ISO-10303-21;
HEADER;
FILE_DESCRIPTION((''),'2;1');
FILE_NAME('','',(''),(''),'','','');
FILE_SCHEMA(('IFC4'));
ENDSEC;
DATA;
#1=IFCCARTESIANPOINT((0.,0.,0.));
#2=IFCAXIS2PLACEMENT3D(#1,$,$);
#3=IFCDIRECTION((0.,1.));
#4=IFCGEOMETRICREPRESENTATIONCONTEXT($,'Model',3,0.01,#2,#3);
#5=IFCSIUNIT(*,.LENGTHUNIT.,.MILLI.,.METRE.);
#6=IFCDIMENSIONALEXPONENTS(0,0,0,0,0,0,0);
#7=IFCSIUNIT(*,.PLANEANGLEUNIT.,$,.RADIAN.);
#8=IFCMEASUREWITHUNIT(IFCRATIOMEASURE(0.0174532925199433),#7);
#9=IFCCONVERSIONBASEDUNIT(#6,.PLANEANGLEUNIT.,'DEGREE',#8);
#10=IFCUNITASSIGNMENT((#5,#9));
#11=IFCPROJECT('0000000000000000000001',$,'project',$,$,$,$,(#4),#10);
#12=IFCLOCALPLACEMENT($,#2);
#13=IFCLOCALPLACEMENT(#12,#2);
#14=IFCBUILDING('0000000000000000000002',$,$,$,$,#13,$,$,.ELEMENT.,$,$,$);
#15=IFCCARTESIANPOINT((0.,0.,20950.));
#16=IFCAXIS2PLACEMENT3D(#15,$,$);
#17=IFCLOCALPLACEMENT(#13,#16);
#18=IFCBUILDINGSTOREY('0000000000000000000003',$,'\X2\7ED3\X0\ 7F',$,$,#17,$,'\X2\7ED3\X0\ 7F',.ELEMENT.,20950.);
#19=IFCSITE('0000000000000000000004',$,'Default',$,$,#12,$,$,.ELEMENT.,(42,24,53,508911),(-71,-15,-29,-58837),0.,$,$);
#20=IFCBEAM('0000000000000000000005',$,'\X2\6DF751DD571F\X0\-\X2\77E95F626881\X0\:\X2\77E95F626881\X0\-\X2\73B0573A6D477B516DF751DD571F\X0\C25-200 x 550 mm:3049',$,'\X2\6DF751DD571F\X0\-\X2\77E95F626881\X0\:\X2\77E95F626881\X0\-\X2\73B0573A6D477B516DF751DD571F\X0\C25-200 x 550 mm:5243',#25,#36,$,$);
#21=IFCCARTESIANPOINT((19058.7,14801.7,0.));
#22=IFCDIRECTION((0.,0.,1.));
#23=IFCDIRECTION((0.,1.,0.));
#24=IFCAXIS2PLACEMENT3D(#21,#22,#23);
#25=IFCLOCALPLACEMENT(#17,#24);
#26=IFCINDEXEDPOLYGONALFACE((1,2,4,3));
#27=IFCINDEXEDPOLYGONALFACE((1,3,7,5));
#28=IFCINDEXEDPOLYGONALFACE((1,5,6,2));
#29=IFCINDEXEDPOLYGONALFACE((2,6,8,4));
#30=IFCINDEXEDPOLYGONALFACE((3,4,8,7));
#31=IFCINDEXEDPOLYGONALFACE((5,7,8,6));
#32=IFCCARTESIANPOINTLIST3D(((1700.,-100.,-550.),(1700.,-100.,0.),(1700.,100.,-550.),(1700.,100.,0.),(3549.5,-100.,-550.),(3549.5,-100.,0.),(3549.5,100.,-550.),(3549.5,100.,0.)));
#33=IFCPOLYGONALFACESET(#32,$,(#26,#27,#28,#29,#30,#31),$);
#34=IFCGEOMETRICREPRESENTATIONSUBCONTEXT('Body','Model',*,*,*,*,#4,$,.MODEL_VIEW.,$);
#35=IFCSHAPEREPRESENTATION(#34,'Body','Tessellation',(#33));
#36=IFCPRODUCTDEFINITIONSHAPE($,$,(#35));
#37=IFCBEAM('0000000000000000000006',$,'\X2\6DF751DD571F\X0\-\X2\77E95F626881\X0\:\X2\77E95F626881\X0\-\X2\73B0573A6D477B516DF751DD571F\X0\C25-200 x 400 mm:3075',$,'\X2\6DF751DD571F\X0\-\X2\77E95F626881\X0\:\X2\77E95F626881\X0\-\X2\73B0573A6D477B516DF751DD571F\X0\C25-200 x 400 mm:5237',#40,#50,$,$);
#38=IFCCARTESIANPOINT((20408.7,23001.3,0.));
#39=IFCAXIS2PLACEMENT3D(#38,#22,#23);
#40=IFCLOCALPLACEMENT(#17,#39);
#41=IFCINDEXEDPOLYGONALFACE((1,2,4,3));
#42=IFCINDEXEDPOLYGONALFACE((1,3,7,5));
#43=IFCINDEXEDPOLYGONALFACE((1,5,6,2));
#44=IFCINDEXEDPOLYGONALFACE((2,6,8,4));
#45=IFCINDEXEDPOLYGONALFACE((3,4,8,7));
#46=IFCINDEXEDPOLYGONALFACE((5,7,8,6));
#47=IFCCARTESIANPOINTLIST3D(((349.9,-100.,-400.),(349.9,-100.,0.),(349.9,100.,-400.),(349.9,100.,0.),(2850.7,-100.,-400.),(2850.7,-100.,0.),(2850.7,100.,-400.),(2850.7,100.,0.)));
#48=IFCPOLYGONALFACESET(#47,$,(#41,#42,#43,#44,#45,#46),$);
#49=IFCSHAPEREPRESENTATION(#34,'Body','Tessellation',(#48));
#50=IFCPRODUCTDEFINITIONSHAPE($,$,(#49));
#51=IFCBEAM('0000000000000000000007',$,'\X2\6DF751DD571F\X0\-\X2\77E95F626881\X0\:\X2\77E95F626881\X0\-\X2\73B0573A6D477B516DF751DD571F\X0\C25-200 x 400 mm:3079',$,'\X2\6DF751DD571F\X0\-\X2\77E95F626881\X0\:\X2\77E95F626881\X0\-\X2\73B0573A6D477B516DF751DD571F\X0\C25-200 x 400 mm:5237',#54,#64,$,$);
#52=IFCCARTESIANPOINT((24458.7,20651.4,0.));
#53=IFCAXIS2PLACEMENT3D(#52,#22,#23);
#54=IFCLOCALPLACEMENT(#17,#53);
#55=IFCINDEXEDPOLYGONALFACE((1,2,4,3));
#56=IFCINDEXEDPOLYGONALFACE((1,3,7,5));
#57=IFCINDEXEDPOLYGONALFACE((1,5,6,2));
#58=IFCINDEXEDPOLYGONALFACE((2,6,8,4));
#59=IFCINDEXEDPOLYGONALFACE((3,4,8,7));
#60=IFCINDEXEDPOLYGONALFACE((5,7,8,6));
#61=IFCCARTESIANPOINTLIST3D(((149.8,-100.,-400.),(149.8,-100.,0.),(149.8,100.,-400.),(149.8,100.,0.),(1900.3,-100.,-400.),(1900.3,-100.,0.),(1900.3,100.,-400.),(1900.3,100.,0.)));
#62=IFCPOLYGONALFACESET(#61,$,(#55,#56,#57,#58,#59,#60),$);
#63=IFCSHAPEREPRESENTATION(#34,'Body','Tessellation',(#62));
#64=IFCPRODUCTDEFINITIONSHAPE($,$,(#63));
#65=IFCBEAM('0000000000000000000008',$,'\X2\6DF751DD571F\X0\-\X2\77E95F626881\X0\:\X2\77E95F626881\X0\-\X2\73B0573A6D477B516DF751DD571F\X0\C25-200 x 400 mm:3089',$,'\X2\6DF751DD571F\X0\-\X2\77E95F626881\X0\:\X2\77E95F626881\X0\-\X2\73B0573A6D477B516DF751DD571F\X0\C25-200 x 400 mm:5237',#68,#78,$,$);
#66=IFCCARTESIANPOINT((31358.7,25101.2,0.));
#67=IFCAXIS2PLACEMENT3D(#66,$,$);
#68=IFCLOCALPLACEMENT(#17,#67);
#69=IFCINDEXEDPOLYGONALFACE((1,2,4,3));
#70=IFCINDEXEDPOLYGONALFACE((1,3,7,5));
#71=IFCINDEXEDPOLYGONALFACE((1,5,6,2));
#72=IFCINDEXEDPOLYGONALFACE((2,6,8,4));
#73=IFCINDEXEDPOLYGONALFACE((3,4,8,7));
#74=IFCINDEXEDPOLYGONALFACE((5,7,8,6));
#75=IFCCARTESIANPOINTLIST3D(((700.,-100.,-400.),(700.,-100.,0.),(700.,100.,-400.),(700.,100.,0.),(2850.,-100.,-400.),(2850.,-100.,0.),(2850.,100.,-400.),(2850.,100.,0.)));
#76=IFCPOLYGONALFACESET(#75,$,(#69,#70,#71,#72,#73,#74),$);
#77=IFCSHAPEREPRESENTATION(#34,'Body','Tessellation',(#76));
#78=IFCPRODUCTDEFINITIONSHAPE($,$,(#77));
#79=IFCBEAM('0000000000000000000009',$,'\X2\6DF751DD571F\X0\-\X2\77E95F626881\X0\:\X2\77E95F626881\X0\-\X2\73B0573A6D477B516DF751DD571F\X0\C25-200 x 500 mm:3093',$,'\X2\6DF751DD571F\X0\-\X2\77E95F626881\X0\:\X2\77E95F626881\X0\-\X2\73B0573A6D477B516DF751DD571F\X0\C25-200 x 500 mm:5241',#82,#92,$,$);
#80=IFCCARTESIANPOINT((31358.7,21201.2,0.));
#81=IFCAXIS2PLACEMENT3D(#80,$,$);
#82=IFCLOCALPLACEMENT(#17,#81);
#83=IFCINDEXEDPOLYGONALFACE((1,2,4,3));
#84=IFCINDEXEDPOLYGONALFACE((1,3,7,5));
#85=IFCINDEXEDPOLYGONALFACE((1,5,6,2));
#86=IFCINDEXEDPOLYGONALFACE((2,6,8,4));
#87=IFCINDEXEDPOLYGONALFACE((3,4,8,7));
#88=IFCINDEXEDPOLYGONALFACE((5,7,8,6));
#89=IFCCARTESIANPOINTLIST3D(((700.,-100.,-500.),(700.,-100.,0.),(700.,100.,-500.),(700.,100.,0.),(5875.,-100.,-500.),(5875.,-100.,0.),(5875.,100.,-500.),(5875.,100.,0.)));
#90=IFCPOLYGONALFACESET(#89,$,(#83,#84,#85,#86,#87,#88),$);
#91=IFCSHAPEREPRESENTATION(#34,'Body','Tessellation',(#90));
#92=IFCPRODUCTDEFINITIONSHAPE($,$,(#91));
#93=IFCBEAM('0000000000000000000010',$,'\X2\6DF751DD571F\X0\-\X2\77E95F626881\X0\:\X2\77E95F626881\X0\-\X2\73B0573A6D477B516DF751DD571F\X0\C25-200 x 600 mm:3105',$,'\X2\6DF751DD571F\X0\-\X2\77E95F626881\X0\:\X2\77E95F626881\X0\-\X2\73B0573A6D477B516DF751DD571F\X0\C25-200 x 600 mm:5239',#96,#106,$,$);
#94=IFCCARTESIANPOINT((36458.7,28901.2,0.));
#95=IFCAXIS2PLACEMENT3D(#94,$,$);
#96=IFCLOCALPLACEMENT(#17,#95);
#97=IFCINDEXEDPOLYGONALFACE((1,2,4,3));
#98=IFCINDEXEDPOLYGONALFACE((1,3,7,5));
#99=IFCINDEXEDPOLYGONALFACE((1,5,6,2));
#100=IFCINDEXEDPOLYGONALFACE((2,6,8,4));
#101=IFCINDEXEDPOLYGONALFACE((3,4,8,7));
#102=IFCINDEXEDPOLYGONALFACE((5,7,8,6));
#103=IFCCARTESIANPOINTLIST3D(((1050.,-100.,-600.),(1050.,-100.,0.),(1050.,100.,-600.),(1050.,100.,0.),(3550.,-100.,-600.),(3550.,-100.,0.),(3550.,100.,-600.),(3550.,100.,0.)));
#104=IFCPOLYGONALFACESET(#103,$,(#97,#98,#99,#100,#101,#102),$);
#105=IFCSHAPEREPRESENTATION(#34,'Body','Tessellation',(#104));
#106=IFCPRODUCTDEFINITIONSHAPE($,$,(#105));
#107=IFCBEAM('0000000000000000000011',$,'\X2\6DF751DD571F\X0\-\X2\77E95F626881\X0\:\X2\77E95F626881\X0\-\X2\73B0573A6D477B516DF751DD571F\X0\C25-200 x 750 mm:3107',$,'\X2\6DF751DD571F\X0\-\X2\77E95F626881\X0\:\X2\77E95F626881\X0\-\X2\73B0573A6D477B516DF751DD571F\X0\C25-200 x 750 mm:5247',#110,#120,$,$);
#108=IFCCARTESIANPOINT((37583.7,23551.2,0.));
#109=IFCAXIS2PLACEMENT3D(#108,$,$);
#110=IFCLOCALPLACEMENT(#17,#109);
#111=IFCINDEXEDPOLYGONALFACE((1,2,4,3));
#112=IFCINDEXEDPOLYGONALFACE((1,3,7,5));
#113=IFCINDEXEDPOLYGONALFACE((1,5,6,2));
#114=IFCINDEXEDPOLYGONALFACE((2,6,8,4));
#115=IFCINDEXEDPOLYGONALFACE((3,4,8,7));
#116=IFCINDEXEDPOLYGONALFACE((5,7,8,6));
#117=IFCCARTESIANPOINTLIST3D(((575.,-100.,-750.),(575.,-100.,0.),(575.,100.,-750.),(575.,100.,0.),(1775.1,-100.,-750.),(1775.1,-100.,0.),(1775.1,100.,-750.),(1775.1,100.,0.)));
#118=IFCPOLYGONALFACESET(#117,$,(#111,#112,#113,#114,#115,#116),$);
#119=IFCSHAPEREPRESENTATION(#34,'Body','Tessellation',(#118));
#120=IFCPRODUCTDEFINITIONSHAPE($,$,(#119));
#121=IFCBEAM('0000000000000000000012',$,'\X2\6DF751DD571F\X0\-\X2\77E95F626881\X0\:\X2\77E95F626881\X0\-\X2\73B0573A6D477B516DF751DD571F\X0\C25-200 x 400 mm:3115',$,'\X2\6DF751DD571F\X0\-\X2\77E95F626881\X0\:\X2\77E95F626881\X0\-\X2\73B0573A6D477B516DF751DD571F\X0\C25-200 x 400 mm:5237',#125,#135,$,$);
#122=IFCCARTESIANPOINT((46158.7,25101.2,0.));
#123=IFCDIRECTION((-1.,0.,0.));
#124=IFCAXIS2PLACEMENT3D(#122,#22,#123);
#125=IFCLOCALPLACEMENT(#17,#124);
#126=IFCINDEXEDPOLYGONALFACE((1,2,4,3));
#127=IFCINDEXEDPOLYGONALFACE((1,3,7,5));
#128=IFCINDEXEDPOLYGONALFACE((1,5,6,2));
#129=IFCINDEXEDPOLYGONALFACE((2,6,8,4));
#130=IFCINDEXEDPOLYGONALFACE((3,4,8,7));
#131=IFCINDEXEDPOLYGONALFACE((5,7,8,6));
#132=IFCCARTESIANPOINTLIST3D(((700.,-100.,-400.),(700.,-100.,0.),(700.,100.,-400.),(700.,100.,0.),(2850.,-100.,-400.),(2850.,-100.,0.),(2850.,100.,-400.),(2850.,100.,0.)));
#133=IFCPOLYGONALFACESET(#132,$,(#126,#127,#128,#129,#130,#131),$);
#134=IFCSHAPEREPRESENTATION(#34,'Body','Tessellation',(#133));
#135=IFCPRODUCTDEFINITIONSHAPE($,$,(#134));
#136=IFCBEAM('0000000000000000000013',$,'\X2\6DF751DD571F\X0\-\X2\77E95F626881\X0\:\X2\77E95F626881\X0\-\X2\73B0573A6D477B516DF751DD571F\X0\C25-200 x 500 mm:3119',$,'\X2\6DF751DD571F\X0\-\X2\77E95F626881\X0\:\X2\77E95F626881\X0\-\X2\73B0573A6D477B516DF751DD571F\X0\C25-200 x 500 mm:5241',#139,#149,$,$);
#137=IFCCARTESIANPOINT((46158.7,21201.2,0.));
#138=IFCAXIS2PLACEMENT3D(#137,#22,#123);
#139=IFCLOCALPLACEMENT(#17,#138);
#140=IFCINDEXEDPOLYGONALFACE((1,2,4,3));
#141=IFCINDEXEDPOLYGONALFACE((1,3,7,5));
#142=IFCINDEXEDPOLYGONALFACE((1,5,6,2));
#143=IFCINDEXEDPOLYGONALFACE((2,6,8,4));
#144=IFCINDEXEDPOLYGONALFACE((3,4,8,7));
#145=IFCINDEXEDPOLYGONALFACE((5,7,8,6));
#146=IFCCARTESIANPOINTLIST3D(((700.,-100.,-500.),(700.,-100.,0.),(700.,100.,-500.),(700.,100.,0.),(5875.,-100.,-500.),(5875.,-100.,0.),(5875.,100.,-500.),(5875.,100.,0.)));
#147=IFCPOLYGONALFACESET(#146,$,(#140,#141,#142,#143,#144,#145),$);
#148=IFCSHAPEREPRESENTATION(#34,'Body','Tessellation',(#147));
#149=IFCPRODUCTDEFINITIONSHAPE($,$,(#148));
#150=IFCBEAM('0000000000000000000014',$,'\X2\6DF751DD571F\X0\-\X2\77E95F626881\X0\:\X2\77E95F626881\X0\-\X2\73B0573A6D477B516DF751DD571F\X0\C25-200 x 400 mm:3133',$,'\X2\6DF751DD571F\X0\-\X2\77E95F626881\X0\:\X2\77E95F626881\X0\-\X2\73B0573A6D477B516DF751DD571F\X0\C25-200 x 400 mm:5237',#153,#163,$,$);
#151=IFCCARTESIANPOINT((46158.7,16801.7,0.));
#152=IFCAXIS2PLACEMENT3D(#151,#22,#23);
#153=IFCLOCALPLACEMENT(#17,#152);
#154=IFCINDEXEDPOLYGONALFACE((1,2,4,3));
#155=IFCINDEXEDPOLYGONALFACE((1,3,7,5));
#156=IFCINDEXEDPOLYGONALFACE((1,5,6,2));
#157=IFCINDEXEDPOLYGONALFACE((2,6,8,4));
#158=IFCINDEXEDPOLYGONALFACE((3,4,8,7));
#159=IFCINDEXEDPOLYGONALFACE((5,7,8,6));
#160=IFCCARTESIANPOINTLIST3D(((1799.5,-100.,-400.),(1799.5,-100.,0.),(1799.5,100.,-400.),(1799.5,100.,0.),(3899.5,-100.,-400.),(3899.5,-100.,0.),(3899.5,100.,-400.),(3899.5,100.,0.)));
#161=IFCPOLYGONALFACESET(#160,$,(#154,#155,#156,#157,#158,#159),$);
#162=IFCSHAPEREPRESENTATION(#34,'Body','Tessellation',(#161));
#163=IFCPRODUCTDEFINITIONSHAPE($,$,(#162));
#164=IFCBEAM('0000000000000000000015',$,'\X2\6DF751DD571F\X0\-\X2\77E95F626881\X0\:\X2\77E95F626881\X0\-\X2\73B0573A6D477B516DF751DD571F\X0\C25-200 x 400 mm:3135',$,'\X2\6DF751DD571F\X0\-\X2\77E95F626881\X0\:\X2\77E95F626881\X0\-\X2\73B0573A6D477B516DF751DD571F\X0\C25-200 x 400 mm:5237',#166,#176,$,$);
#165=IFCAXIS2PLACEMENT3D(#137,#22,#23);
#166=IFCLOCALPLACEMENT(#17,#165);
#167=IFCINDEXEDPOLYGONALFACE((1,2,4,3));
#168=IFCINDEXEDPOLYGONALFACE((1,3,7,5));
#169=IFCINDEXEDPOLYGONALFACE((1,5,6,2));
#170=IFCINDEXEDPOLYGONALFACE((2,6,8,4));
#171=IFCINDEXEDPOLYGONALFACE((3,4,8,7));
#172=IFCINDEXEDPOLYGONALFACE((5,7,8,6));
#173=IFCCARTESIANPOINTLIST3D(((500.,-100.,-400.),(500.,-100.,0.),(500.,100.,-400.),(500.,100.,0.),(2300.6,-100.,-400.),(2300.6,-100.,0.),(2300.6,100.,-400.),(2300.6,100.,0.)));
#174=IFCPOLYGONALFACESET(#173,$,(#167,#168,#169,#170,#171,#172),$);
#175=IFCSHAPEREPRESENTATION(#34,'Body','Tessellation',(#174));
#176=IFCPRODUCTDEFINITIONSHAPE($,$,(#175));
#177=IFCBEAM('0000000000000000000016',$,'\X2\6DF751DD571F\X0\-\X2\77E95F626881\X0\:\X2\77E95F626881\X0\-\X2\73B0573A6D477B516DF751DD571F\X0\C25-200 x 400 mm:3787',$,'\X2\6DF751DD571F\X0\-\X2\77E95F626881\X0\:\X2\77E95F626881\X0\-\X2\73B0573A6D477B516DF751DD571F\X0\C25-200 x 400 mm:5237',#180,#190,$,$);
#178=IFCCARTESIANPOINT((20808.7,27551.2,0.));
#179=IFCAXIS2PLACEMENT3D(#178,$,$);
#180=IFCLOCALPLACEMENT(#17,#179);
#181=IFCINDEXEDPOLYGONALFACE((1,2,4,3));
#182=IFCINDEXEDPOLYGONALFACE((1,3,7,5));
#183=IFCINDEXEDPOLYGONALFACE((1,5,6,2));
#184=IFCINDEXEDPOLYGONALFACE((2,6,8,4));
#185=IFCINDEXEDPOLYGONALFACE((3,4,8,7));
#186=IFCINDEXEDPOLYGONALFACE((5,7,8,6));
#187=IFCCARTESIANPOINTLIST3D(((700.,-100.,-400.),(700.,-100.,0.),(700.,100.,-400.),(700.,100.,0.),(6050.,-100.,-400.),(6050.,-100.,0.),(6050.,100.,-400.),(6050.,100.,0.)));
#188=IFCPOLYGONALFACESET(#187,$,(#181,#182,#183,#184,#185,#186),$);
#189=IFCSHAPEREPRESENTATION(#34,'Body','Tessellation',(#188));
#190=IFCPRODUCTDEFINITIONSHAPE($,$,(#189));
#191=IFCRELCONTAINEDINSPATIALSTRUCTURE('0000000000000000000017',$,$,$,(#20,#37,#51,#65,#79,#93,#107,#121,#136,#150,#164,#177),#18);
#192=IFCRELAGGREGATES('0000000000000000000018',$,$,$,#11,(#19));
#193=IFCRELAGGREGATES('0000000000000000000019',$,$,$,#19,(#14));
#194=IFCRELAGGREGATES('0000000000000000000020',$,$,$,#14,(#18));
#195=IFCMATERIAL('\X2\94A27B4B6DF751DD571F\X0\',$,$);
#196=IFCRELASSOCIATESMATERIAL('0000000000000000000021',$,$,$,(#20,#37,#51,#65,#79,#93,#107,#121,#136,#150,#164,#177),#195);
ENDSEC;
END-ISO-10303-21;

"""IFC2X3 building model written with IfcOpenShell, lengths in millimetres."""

from ifc_helpers import new_model, entity, si_unit, converted_unit, direction, frame, frame_2d, origin, place, context, subcontext, project, spatial, rectangle, extrude, material, element, save


model = new_model("IFC2X3")

# Units and contexts
model_context = context("Model", 3, precision=0.01, world=origin(), true_north=direction((0.0, 1.0)))
body_context = subcontext(model_context, "Body", "Model", "MODEL_VIEW")
ifc_project = project(units=[si_unit("LENGTHUNIT", "METRE", prefix="MILLI"), converted_unit("PLANEANGLEUNIT", "DEGREE", entity("IfcRatioMeasure", 0.0174532925199433), si_unit("PLANEANGLEUNIT", "RADIAN"), dimensions=[0, 0, 0, 0, 0, 0, 0])], contexts=[model_context])

# Site, building, storey
site_placement = place(None, origin())
site = spatial("IfcSite", under=ifc_project, at=site_placement, Name="Default", CompositionType="ELEMENT", RefLatitude=(42, 24, 53, 508911), RefLongitude=(-71, -15, -29, -58837), RefElevation=0.0)
building_placement = place(site_placement, origin())
building = spatial("IfcBuilding", under=site, at=building_placement, CompositionType="ELEMENT")
storey_placement = place(building_placement, frame((0.0, 0.0, 20950.0)))
storey = spatial("IfcBuildingStorey", under=building, at=storey_placement, Name="结 7F", LongName="结 7F", CompositionType="ELEMENT", Elevation=20950.0)

# Beams
ifc_material = material(Name="钢筋混凝土")
beam_1_placement = place(storey_placement, frame((19058.7, 14801.7, 0.0), z_axis=(0.0, 0.0, 1.0), x_axis=(0.0, 1.0, 0.0)))
element("IfcBeam", 1, at=beam_1_placement, inside=storey, material=ifc_material, Name="混凝土-矩形梁:矩形梁-现场浇筑混凝土C25-200 x 550 mm:3049", ObjectType="混凝土-矩形梁:矩形梁-现场浇筑混凝土C25-200 x 550 mm:5243", context=body_context, shape_type="SweptSolid", body=[
    extrude(rectangle(XDim=550.0, YDim=200.0, at=frame_2d((0.0, 0.0), x_axis=(1.0, 0.0))), frame((1700.0, 0.0, -275.0), z_axis=(1.0, 0.0, 0.0), x_axis=(0.0, 0.0, -1.0)), (0.0, 0.0, 1.0), 1849.5),
])
beam_2_placement = place(storey_placement, frame((20408.7, 23001.3, 0.0), z_axis=(0.0, 0.0, 1.0), x_axis=(0.0, 1.0, 0.0)))
element("IfcBeam", 2, at=beam_2_placement, inside=storey, material=ifc_material, Name="混凝土-矩形梁:矩形梁-现场浇筑混凝土C25-200 x 400 mm:3075", ObjectType="混凝土-矩形梁:矩形梁-现场浇筑混凝土C25-200 x 400 mm:5237", context=body_context, shape_type="SweptSolid", body=[
    extrude(rectangle(XDim=400.0, YDim=200.0, at=frame_2d((0.0, 0.0), x_axis=(1.0, 0.0))), frame((349.9, 0.0, -200.0), z_axis=(1.0, 0.0, 0.0), x_axis=(0.0, 0.0, -1.0)), (0.0, 0.0, 1.0), 2500.8),
])
beam_3_placement = place(storey_placement, frame((24458.7, 20651.4, 0.0), z_axis=(0.0, 0.0, 1.0), x_axis=(0.0, 1.0, 0.0)))
element("IfcBeam", 3, at=beam_3_placement, inside=storey, material=ifc_material, Name="混凝土-矩形梁:矩形梁-现场浇筑混凝土C25-200 x 400 mm:3079", ObjectType="混凝土-矩形梁:矩形梁-现场浇筑混凝土C25-200 x 400 mm:5237", context=body_context, shape_type="SweptSolid", body=[
    extrude(rectangle(XDim=400.0, YDim=200.0, at=frame_2d((0.0, 0.0), x_axis=(1.0, 0.0))), frame((149.8, 0.0, -200.0), z_axis=(1.0, 0.0, 0.0), x_axis=(0.0, 0.0, -1.0)), (0.0, 0.0, 1.0), 1750.5),
])
beam_4_placement = place(storey_placement, frame((31358.7, 25101.2, 0.0)))
element("IfcBeam", 4, at=beam_4_placement, inside=storey, material=ifc_material, Name="混凝土-矩形梁:矩形梁-现场浇筑混凝土C25-200 x 400 mm:3089", ObjectType="混凝土-矩形梁:矩形梁-现场浇筑混凝土C25-200 x 400 mm:5237", context=body_context, shape_type="SweptSolid", body=[
    extrude(rectangle(XDim=400.0, YDim=200.0, at=frame_2d((0.0, 0.0), x_axis=(1.0, 0.0))), frame((700.0, 0.0, -200.0), z_axis=(1.0, 0.0, 0.0), x_axis=(0.0, 0.0, -1.0)), (0.0, 0.0, 1.0), 2150.0),
])
beam_5_placement = place(storey_placement, frame((31358.7, 21201.2, 0.0)))
element("IfcBeam", 5, at=beam_5_placement, inside=storey, material=ifc_material, Name="混凝土-矩形梁:矩形梁-现场浇筑混凝土C25-200 x 500 mm:3093", ObjectType="混凝土-矩形梁:矩形梁-现场浇筑混凝土C25-200 x 500 mm:5241", context=body_context, shape_type="SweptSolid", body=[
    extrude(rectangle(XDim=500.0, YDim=200.0, at=frame_2d((0.0, 0.0), x_axis=(1.0, 0.0))), frame((700.0, 0.0, -250.0), z_axis=(1.0, 0.0, 0.0), x_axis=(0.0, 0.0, -1.0)), (0.0, 0.0, 1.0), 5175.0),
])
beam_6_placement = place(storey_placement, frame((36458.7, 28901.2, 0.0)))
element("IfcBeam", 6, at=beam_6_placement, inside=storey, material=ifc_material, Name="混凝土-矩形梁:矩形梁-现场浇筑混凝土C25-200 x 600 mm:3105", ObjectType="混凝土-矩形梁:矩形梁-现场浇筑混凝土C25-200 x 600 mm:5239", context=body_context, shape_type="SweptSolid", body=[
    extrude(rectangle(XDim=600.0, YDim=200.0, at=frame_2d((0.0, 0.0), x_axis=(1.0, 0.0))), frame((1050.0, 0.0, -300.0), z_axis=(1.0, 0.0, 0.0), x_axis=(0.0, 0.0, -1.0)), (0.0, 0.0, 1.0), 2500.0),
])
beam_7_placement = place(storey_placement, frame((37583.7, 23551.2, 0.0)))
element("IfcBeam", 7, at=beam_7_placement, inside=storey, material=ifc_material, Name="混凝土-矩形梁:矩形梁-现场浇筑混凝土C25-200 x 750 mm:3107", ObjectType="混凝土-矩形梁:矩形梁-现场浇筑混凝土C25-200 x 750 mm:5247", context=body_context, shape_type="SweptSolid", body=[
    extrude(rectangle(XDim=750.0, YDim=200.0, at=frame_2d((0.0, 0.0), x_axis=(1.0, 0.0))), frame((575.0, 0.0, -375.0), z_axis=(1.0, 0.0, 0.0), x_axis=(0.0, 0.0, -1.0)), (0.0, 0.0, 1.0), 1200.1),
])
beam_8_placement = place(storey_placement, frame((46158.7, 25101.2, 0.0), z_axis=(0.0, 0.0, 1.0), x_axis=(-1.0, 0.0, 0.0)))
element("IfcBeam", 8, at=beam_8_placement, inside=storey, material=ifc_material, Name="混凝土-矩形梁:矩形梁-现场浇筑混凝土C25-200 x 400 mm:3115", ObjectType="混凝土-矩形梁:矩形梁-现场浇筑混凝土C25-200 x 400 mm:5237", context=body_context, shape_type="SweptSolid", body=[
    extrude(rectangle(XDim=400.0, YDim=200.0, at=frame_2d((0.0, 0.0), x_axis=(1.0, 0.0))), frame((700.0, 0.0, -200.0), z_axis=(1.0, 0.0, 0.0), x_axis=(0.0, 0.0, -1.0)), (0.0, 0.0, 1.0), 2150.0),
])
beam_9_placement = place(storey_placement, frame((46158.7, 21201.2, 0.0), z_axis=(0.0, 0.0, 1.0), x_axis=(-1.0, 0.0, 0.0)))
element("IfcBeam", 9, at=beam_9_placement, inside=storey, material=ifc_material, Name="混凝土-矩形梁:矩形梁-现场浇筑混凝土C25-200 x 500 mm:3119", ObjectType="混凝土-矩形梁:矩形梁-现场浇筑混凝土C25-200 x 500 mm:5241", context=body_context, shape_type="SweptSolid", body=[
    extrude(rectangle(XDim=500.0, YDim=200.0, at=frame_2d((0.0, 0.0), x_axis=(1.0, 0.0))), frame((700.0, 0.0, -250.0), z_axis=(1.0, 0.0, 0.0), x_axis=(0.0, 0.0, -1.0)), (0.0, 0.0, 1.0), 5175.0),
])
beam_10_placement = place(storey_placement, frame((46158.7, 16801.7, 0.0), z_axis=(0.0, 0.0, 1.0), x_axis=(0.0, 1.0, 0.0)))
element("IfcBeam", 10, at=beam_10_placement, inside=storey, material=ifc_material, Name="混凝土-矩形梁:矩形梁-现场浇筑混凝土C25-200 x 400 mm:3133", ObjectType="混凝土-矩形梁:矩形梁-现场浇筑混凝土C25-200 x 400 mm:5237", context=body_context, shape_type="SweptSolid", body=[
    extrude(rectangle(XDim=400.0, YDim=200.0, at=frame_2d((0.0, 0.0), x_axis=(1.0, 0.0))), frame((1799.5, 0.0, -200.0), z_axis=(1.0, 0.0, 0.0), x_axis=(0.0, 0.0, -1.0)), (0.0, 0.0, 1.0), 2100.0),
])
beam_11_placement = place(storey_placement, frame((46158.7, 21201.2, 0.0), z_axis=(0.0, 0.0, 1.0), x_axis=(0.0, 1.0, 0.0)))
element("IfcBeam", 11, at=beam_11_placement, inside=storey, material=ifc_material, Name="混凝土-矩形梁:矩形梁-现场浇筑混凝土C25-200 x 400 mm:3135", ObjectType="混凝土-矩形梁:矩形梁-现场浇筑混凝土C25-200 x 400 mm:5237", context=body_context, shape_type="SweptSolid", body=[
    extrude(rectangle(XDim=400.0, YDim=200.0, at=frame_2d((0.0, 0.0), x_axis=(1.0, 0.0))), frame((500.0, 0.0, -200.0), z_axis=(1.0, 0.0, 0.0), x_axis=(0.0, 0.0, -1.0)), (0.0, 0.0, 1.0), 1800.6),
])
beam_12_placement = place(storey_placement, frame((20808.7, 27551.2, 0.0)))
element("IfcBeam", 12, at=beam_12_placement, inside=storey, material=ifc_material, Name="混凝土-矩形梁:矩形梁-现场浇筑混凝土C25-200 x 400 mm:3787", ObjectType="混凝土-矩形梁:矩形梁-现场浇筑混凝土C25-200 x 400 mm:5237", context=body_context, shape_type="SweptSolid", body=[
    extrude(rectangle(XDim=400.0, YDim=200.0, at=frame_2d((0.0, 0.0), x_axis=(1.0, 0.0))), frame((700.0, 0.0, -200.0), z_axis=(1.0, 0.0, 0.0), x_axis=(0.0, 0.0, -1.0)), (0.0, 0.0, 1.0), 5350.0),
])

save(model, "model.ifc")
